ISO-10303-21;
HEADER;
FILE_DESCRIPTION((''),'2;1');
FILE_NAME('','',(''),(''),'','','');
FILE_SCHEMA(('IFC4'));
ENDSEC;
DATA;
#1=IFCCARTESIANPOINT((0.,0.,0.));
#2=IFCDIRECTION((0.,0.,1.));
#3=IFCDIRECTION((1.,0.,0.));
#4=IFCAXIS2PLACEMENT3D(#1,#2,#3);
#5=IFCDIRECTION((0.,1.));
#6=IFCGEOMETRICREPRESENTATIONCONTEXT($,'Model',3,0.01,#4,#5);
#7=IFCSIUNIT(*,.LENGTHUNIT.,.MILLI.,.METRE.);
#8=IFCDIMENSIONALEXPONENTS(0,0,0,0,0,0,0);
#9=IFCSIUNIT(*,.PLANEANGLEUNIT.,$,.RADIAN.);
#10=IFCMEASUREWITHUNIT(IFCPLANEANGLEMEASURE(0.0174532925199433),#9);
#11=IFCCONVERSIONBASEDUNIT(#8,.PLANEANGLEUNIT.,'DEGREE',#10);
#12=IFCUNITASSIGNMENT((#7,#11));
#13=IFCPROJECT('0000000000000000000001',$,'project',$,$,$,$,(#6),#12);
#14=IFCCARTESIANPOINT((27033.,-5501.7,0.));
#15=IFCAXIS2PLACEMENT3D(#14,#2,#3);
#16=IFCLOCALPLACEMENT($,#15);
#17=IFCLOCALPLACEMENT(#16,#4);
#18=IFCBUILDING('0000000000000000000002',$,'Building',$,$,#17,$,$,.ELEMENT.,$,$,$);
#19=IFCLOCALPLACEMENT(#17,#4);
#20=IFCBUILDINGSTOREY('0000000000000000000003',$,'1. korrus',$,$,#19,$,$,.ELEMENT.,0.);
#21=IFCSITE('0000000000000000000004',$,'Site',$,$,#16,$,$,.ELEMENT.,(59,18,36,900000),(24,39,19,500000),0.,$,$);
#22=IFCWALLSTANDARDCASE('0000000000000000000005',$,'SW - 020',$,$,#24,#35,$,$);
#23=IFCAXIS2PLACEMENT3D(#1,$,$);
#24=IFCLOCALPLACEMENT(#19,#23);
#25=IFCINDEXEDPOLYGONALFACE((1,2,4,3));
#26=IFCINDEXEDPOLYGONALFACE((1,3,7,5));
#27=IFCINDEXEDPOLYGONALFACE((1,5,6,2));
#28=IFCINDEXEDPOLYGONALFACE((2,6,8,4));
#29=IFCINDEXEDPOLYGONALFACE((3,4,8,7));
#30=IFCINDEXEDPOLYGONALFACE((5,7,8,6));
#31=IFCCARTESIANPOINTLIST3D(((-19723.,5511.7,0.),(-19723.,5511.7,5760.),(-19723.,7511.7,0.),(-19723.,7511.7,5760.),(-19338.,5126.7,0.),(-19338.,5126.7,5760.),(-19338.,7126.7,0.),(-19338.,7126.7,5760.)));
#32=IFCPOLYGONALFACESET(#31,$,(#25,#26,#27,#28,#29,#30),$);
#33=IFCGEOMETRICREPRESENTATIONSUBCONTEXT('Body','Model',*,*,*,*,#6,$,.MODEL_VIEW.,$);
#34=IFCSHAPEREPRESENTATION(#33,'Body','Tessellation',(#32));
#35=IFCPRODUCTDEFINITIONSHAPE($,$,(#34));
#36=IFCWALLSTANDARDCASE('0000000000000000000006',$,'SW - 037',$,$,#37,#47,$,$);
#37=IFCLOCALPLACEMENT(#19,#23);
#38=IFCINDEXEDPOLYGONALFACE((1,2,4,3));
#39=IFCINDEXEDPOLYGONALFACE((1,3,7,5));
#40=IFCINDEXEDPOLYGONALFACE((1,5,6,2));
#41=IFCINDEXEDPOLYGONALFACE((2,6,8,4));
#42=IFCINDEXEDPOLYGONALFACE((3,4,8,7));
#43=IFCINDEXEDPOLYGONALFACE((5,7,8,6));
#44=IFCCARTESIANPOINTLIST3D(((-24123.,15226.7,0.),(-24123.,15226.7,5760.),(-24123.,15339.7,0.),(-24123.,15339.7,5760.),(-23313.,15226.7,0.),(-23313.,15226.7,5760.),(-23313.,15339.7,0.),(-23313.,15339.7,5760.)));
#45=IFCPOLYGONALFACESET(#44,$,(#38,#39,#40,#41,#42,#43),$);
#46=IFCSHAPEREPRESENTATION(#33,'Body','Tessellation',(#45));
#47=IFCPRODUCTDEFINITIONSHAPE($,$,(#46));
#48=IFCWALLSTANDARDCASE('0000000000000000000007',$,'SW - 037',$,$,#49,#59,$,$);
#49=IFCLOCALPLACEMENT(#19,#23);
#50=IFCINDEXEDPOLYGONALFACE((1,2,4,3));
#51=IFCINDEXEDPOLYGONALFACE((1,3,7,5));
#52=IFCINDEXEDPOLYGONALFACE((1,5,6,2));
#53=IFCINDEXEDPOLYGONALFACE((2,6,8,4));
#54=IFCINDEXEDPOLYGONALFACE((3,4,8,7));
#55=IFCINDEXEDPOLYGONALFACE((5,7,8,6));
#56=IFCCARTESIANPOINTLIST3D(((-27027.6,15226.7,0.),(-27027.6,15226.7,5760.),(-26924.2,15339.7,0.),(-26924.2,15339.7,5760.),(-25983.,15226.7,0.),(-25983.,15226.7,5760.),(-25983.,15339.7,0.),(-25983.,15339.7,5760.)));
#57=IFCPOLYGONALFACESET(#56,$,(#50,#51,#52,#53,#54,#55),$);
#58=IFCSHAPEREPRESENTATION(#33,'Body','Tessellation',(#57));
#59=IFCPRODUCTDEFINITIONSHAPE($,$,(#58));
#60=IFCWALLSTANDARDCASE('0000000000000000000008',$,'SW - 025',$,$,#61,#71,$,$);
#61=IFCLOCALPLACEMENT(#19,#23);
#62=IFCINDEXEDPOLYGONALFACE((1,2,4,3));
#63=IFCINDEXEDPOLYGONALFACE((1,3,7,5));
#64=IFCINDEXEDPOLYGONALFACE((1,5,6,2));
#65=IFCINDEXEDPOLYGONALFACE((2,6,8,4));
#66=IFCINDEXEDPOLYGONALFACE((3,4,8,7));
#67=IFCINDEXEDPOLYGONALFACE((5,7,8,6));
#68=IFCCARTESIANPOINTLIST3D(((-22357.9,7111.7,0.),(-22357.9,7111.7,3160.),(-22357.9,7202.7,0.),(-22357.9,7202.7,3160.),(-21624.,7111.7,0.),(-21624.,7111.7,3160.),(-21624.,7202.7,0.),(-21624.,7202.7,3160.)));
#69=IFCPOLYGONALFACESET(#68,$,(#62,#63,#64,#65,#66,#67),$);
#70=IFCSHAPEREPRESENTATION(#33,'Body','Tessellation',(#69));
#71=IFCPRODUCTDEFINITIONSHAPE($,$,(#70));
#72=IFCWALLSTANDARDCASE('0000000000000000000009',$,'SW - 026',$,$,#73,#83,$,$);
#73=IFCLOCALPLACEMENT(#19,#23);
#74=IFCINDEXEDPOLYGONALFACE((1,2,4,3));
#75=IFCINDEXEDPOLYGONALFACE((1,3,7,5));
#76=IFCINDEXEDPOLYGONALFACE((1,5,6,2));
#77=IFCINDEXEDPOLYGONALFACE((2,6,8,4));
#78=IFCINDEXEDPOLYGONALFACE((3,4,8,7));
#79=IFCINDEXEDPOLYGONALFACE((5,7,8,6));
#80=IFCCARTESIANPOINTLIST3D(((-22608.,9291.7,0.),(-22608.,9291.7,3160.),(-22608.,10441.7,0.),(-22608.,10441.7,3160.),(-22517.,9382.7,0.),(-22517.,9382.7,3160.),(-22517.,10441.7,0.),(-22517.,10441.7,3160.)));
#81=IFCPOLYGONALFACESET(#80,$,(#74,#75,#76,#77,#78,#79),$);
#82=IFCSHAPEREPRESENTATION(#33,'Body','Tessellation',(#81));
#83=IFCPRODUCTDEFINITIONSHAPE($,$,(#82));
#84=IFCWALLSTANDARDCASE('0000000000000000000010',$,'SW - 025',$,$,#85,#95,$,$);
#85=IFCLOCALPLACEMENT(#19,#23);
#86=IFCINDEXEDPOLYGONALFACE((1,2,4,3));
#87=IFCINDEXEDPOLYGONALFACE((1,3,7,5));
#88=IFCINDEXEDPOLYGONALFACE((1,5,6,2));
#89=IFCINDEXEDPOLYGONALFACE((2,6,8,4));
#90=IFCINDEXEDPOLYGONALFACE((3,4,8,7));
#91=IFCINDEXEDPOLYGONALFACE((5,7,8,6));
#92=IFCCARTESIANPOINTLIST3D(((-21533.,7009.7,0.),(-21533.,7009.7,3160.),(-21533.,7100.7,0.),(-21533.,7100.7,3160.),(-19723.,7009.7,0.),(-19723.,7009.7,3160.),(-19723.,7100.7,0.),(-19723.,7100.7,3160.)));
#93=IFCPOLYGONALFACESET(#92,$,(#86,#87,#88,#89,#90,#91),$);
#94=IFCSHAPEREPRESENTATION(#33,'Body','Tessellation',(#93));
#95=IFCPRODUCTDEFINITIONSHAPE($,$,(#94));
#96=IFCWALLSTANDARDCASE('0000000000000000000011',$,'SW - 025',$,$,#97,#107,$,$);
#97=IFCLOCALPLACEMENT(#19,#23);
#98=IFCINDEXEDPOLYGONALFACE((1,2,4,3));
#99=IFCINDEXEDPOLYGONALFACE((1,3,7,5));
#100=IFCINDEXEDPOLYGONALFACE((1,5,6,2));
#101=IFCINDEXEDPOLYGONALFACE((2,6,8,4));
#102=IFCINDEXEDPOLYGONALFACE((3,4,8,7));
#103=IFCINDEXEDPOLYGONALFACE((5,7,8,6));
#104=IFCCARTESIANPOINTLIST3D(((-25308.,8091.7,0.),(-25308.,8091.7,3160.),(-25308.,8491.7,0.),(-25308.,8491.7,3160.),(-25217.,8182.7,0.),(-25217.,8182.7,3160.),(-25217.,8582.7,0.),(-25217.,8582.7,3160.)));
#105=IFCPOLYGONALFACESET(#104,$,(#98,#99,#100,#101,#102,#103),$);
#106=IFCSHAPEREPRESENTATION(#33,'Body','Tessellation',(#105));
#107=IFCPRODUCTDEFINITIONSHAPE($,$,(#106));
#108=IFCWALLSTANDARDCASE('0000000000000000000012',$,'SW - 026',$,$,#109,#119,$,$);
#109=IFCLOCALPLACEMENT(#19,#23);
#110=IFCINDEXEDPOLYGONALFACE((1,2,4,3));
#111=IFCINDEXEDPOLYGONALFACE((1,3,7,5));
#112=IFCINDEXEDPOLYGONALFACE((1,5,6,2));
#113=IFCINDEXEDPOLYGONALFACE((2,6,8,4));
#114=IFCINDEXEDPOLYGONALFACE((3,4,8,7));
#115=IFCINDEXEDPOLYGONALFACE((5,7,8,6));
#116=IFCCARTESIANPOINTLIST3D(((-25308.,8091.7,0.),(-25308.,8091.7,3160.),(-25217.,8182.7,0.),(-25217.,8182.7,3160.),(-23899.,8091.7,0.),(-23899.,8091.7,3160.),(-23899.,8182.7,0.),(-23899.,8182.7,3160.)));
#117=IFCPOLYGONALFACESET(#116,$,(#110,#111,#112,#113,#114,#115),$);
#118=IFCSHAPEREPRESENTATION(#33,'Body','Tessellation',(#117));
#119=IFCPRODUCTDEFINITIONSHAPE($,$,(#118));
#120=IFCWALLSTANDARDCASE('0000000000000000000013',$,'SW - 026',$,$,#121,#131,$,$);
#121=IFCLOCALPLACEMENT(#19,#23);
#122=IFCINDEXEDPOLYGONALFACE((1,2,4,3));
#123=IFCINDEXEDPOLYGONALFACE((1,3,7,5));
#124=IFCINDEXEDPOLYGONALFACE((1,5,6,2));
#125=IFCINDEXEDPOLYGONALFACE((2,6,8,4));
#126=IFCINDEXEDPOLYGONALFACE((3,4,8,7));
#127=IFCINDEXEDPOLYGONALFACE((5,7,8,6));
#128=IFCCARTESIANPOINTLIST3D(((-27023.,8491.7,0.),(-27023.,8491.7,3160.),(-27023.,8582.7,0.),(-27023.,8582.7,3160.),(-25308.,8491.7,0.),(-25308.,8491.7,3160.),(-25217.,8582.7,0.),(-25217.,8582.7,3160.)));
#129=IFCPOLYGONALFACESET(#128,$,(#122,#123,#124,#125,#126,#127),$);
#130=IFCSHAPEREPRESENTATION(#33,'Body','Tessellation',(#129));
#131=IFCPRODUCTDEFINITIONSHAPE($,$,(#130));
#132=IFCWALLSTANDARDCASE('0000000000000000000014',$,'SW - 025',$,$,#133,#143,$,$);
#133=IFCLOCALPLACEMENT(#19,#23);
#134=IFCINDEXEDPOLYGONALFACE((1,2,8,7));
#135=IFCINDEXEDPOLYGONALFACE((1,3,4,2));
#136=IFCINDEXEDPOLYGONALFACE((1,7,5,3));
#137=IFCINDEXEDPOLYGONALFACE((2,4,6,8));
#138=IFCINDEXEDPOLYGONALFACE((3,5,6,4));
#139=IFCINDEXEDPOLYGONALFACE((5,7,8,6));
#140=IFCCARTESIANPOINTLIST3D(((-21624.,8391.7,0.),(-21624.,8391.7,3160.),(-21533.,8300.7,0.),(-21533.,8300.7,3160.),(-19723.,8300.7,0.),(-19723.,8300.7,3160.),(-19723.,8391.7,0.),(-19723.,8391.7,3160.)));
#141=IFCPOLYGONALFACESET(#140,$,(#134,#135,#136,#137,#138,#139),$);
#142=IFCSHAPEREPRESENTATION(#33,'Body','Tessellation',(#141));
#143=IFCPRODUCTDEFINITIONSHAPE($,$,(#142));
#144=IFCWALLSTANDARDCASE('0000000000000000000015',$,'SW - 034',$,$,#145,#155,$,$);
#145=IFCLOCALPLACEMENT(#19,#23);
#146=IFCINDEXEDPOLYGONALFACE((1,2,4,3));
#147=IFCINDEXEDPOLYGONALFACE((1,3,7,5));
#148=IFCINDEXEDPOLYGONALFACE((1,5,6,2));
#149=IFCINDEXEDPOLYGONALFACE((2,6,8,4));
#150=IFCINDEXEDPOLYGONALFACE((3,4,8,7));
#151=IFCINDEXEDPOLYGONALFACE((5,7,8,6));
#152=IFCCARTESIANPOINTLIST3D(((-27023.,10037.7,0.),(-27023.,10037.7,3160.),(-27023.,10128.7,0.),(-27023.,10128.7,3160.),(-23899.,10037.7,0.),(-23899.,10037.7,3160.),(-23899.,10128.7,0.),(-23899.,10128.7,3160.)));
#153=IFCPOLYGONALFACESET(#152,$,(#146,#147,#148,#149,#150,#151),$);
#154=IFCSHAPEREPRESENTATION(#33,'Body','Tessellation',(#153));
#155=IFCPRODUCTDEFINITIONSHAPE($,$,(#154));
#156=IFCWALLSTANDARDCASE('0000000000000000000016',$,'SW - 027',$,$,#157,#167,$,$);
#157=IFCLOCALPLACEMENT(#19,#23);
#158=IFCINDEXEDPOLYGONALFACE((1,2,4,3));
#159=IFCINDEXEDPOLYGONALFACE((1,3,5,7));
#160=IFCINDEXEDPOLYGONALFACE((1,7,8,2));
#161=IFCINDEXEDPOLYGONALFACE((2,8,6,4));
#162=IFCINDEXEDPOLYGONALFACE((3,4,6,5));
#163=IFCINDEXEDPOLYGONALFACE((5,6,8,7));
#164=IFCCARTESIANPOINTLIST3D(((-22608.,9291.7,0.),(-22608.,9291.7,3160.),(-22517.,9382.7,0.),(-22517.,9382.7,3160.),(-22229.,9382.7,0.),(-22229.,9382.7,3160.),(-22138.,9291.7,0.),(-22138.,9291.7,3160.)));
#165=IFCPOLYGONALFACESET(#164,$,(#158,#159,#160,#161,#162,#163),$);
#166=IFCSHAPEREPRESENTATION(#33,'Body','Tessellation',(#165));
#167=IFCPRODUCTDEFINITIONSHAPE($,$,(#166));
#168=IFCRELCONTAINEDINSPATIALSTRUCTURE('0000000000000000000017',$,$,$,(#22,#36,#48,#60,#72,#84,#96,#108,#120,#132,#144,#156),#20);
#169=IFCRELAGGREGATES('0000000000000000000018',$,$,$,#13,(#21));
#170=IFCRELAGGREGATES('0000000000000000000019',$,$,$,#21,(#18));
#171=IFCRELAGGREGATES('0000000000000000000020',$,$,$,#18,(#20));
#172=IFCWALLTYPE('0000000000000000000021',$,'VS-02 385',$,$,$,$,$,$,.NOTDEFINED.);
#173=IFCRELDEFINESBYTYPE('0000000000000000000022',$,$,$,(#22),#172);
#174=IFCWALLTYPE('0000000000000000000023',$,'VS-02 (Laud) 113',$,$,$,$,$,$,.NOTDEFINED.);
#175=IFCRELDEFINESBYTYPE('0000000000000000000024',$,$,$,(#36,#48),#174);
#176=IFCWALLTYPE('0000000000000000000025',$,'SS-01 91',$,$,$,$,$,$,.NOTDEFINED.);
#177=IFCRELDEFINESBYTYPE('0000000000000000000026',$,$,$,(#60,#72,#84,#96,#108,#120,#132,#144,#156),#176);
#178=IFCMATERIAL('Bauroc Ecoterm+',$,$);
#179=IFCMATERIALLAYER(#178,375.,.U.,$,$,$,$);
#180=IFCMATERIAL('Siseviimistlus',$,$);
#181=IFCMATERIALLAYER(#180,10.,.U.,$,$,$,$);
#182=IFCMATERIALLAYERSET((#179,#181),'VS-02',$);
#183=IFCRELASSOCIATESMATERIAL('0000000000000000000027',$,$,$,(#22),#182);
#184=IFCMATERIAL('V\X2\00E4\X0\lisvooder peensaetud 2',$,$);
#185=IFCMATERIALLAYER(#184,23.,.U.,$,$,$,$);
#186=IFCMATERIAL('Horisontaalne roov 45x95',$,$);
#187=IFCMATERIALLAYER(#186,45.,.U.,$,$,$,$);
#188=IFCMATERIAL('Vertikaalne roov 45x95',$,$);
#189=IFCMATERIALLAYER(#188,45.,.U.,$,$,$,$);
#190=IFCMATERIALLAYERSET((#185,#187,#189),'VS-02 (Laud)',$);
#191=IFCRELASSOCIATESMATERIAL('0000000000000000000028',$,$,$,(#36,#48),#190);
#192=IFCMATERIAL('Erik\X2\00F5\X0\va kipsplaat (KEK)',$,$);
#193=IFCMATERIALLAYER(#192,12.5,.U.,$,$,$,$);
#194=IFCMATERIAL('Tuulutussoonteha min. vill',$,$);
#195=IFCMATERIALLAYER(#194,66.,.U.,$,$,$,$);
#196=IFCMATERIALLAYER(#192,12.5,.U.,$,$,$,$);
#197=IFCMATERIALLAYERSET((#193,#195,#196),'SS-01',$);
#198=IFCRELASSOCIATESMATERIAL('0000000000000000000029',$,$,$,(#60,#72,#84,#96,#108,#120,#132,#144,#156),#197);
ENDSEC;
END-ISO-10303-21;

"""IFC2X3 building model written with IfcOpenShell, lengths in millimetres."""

from ifc_helpers import new_model, entity, si_unit, converted_unit, direction, frame, origin_with_axes, place, context, subcontext, project, spatial, polyline, outline, extrude, material, layer, layer_set, layer_usage, type_object, element, save


model = new_model("IFC2X3")

# Units and contexts
model_context = context("Model", 3, precision=0.01, world=origin_with_axes(), true_north=direction((0.0, 1.0)))
body_context = subcontext(model_context, "Body", "Model", "MODEL_VIEW")
ifc_project = project(units=[si_unit("LENGTHUNIT", "METRE", prefix="MILLI"), converted_unit("PLANEANGLEUNIT", "DEGREE", entity("IfcPlaneAngleMeasure", 0.0174532925199433), si_unit("PLANEANGLEUNIT", "RADIAN"), dimensions=[0, 0, 0, 0, 0, 0, 0])], contexts=[model_context])

# Site, building, storey
site_placement = place(None, frame((27033.0, -5501.7, 0.0), z_axis=(0.0, 0.0, 1.0), x_axis=(1.0, 0.0, 0.0)))
site = spatial("IfcSite", under=ifc_project, at=site_placement, Name="Site", CompositionType="ELEMENT", RefLatitude=(59, 18, 36, 900000), RefLongitude=(24, 39, 19, 500000), RefElevation=0.0)
building_placement = place(site_placement, origin_with_axes())
building = spatial("IfcBuilding", under=site, at=building_placement, Name="Building", CompositionType="ELEMENT")
storey_placement = place(building_placement, origin_with_axes())
storey = spatial("IfcBuildingStorey", under=building, at=storey_placement, Name="1. korrus", CompositionType="ELEMENT", Elevation=0.0)

# Wall
ifc_material_1 = material(Name="Bauroc Ecoterm+")
ifc_layer_1 = layer(ifc_material_1, 375.0, ventilated="UNKNOWN")
ifc_material_2 = material(Name="Siseviimistlus")
ifc_layer_2 = layer(ifc_material_2, 10.0, ventilated="UNKNOWN")
ifc_layer_set_1 = layer_set([ifc_layer_1, ifc_layer_2], Name="VS-02")
ifc_layer_usage_1 = layer_usage(ifc_layer_set_1, "AXIS2", "NEGATIVE", 385.0)
wall_type_1 = type_object("IfcWallType", Name="VS-02 385", PredefinedType="NOTDEFINED")
wall_1_placement = place(storey_placement, frame((-19723.0, 7511.7, 0.0), z_axis=(0.0, 0.0, 1.0), x_axis=(0.0, -1.0, 0.0)))
element("IfcWallStandardCase", 1, at=wall_1_placement, inside=storey, type_object=wall_type_1, material=ifc_layer_usage_1, Name="SW - 020", context=body_context, shape_type="SweptSolid", body=[
    extrude(outline(polyline([(0.0, 0.0), (2000.0, 0.0), (2385.0, 385.0), (385.0, 385.0), (0.0, 0.0)])), origin_with_axes(), (0.0, 0.0, 1.0), 5760.0),
])

# Walls
ifc_material_3 = material(Name="Välisvooder peensaetud 2")
ifc_layer_3 = layer(ifc_material_3, 23.0, ventilated="UNKNOWN")
ifc_material_4 = material(Name="Horisontaalne roov 45x95")
ifc_layer_4 = layer(ifc_material_4, 45.0, ventilated="UNKNOWN")
ifc_material_5 = material(Name="Vertikaalne roov 45x95")
ifc_layer_5 = layer(ifc_material_5, 45.0, ventilated="UNKNOWN")
ifc_layer_set_2 = layer_set([ifc_layer_3, ifc_layer_4, ifc_layer_5], Name="VS-02 (Laud)")
ifc_layer_usage_2 = layer_usage(ifc_layer_set_2, "AXIS2", "POSITIVE", -113.0)
wall_type_2 = type_object("IfcWallType", Name="VS-02 (Laud) 113", PredefinedType="NOTDEFINED")
wall_2_placement = place(storey_placement, frame((-23313.0, 15226.7, 0.0), z_axis=(0.0, 0.0, 1.0), x_axis=(-1.0, 0.0, 0.0)))
element("IfcWallStandardCase", 2, at=wall_2_placement, inside=storey, type_object=wall_type_2, material=ifc_layer_usage_2, Name="SW - 037", context=body_context, shape_type="SweptSolid", body=[
    extrude(outline(polyline([(0.0, -113.0), (810.0, -113.0), (810.0, 0.0), (0.0, 0.0), (0.0, -113.0)])), origin_with_axes(), (0.0, 0.0, 1.0), 5760.0),
])
ifc_layer_usage_3 = layer_usage(ifc_layer_set_2, "AXIS2", "POSITIVE", -113.0)
wall_3_placement = place(storey_placement, frame((-25983.0, 15226.7, 0.0), z_axis=(0.0, 0.0, 1.0), x_axis=(-1.0, 0.0, 0.0)))
element("IfcWallStandardCase", 3, at=wall_3_placement, inside=storey, type_object=wall_type_2, material=ifc_layer_usage_3, Name="SW - 037", context=body_context, shape_type="SweptSolid", body=[
    extrude(outline(polyline([(0.0, -113.0), (941.2, -113.0), (1044.7, 0.0), (0.0, 0.0), (0.0, -113.0)])), origin_with_axes(), (0.0, 0.0, 1.0), 5760.0),
])
ifc_material_6 = material(Name="Erikõva kipsplaat (KEK)")
ifc_layer_6 = layer(ifc_material_6, 12.5, ventilated="UNKNOWN")
ifc_material_7 = material(Name="Tuulutussoonteha min. vill")
ifc_layer_7 = layer(ifc_material_7, 66.0, ventilated="UNKNOWN")
ifc_layer_8 = layer(ifc_material_6, 12.5, ventilated="UNKNOWN")
ifc_layer_set_3 = layer_set([ifc_layer_6, ifc_layer_7, ifc_layer_8], Name="SS-01")
ifc_layer_usage_4 = layer_usage(ifc_layer_set_3, "AXIS2", "POSITIVE", -91.0)
wall_type_3 = type_object("IfcWallType", Name="SS-01 91", PredefinedType="NOTDEFINED")
wall_4_placement = place(storey_placement, frame((-22357.9, 7202.7, 0.0), z_axis=(0.0, 0.0, 1.0), x_axis=(1.0, 0.0, 0.0)))
element("IfcWallStandardCase", 4, at=wall_4_placement, inside=storey, type_object=wall_type_3, material=ifc_layer_usage_4, Name="SW - 025", context=body_context, shape_type="SweptSolid", body=[
    extrude(outline(polyline([(0.0, -91.0), (733.9, -91.0), (733.9, 0.0), (0.0, 0.0), (0.0, -91.0)])), origin_with_axes(), (0.0, 0.0, 1.0), 3160.0),
])
ifc_layer_usage_5 = layer_usage(ifc_layer_set_3, "AXIS2", "NEGATIVE", 91.0)
wall_5_placement = place(storey_placement, frame((-22608.0, 10441.7, 0.0), z_axis=(0.0, 0.0, 1.0), x_axis=(0.0, -1.0, 0.0)))
element("IfcWallStandardCase", 5, at=wall_5_placement, inside=storey, type_object=wall_type_3, material=ifc_layer_usage_5, Name="SW - 026", context=body_context, shape_type="SweptSolid", body=[
    extrude(outline(polyline([(0.0, 0.0), (1150.0, 0.0), (1059.0, 91.0), (0.0, 91.0), (0.0, 0.0)])), origin_with_axes(), (0.0, 0.0, 1.0), 3160.0),
])
ifc_layer_usage_6 = layer_usage(ifc_layer_set_3, "AXIS2", "POSITIVE", -91.0)
wall_6_placement = place(storey_placement, frame((-19723.0, 7009.7, 0.0), z_axis=(0.0, 0.0, 1.0), x_axis=(-1.0, 0.0, 0.0)))
element("IfcWallStandardCase", 6, at=wall_6_placement, inside=storey, type_object=wall_type_3, material=ifc_layer_usage_6, Name="SW - 025", context=body_context, shape_type="SweptSolid", body=[
    extrude(outline(polyline([(0.0, -91.0), (1810.0, -91.0), (1810.0, 0.0), (0.0, 0.0), (0.0, -91.0)])), origin_with_axes(), (0.0, 0.0, 1.0), 3160.0),
])
ifc_layer_usage_7 = layer_usage(ifc_layer_set_3, "AXIS2", "POSITIVE", -91.0)
wall_7_placement = place(storey_placement, frame((-25308.0, 8091.7, 0.0), z_axis=(0.0, 0.0, 1.0), x_axis=(0.0, 1.0, 0.0)))
element("IfcWallStandardCase", 7, at=wall_7_placement, inside=storey, type_object=wall_type_3, material=ifc_layer_usage_7, Name="SW - 025", context=body_context, shape_type="SweptSolid", body=[
    extrude(outline(polyline([(91.0, -91.0), (491.0, -91.0), (400.0, 0.0), (0.0, 0.0), (91.0, -91.0)])), origin_with_axes(), (0.0, 0.0, 1.0), 3160.0),
])
ifc_layer_usage_8 = layer_usage(ifc_layer_set_3, "AXIS2", "NEGATIVE", 91.0)
wall_8_placement = place(storey_placement, frame((-25308.0, 8091.7, 0.0), z_axis=(0.0, 0.0, 1.0), x_axis=(1.0, 0.0, 0.0)))
element("IfcWallStandardCase", 8, at=wall_8_placement, inside=storey, type_object=wall_type_3, material=ifc_layer_usage_8, Name="SW - 026", context=body_context, shape_type="SweptSolid", body=[
    extrude(outline(polyline([(0.0, 0.0), (1409.0, 0.0), (1409.0, 91.0), (91.0, 91.0), (0.0, 0.0)])), origin_with_axes(), (0.0, 0.0, 1.0), 3160.0),
])
ifc_layer_usage_9 = layer_usage(ifc_layer_set_3, "AXIS2", "POSITIVE", -91.0)
wall_9_placement = place(storey_placement, frame((-25308.0, 8491.7, 0.0), z_axis=(0.0, 0.0, 1.0), x_axis=(-1.0, 0.0, 0.0)))
element("IfcWallStandardCase", 9, at=wall_9_placement, inside=storey, type_object=wall_type_3, material=ifc_layer_usage_9, Name="SW - 026", context=body_context, shape_type="SweptSolid", body=[
    extrude(outline(polyline([(-91.0, -91.0), (1715.0, -91.0), (1715.0, 0.0), (0.0, 0.0), (-91.0, -91.0)])), origin_with_axes(), (0.0, 0.0, 1.0), 3160.0),
])
ifc_layer_usage_10 = layer_usage(ifc_layer_set_3, "AXIS2", "NEGATIVE", 91.0)
wall_10_placement = place(storey_placement, frame((-19723.0, 8391.7, 0.0), z_axis=(0.0, 0.0, 1.0), x_axis=(-1.0, 0.000001, 0.0)))
element("IfcWallStandardCase", 10, at=wall_10_placement, inside=storey, type_object=wall_type_3, material=ifc_layer_usage_10, Name="SW - 025", context=body_context, shape_type="SweptSolid", body=[
    extrude(outline(polyline([(0.0, 0.0), (1901.0, 0.0), (1810.0, 91.0), (0.0, 91.0), (0.0, 0.0)])), origin_with_axes(), (0.0, 0.0, 1.0), 3160.0),
])
ifc_layer_usage_11 = layer_usage(ifc_layer_set_3, "AXIS2", "NEGATIVE", 91.0)
wall_11_placement = place(storey_placement, frame((-27023.0, 10037.7, 0.0), z_axis=(0.0, 0.0, 1.0), x_axis=(1.0, 0.0, 0.0)))
element("IfcWallStandardCase", 11, at=wall_11_placement, inside=storey, type_object=wall_type_3, material=ifc_layer_usage_11, Name="SW - 034", context=body_context, shape_type="SweptSolid", body=[
    extrude(outline(polyline([(0.0, 0.0), (3124.0, 0.0), (3124.0, 91.0), (0.0, 91.0), (0.0, 0.0)])), origin_with_axes(), (0.0, 0.0, 1.0), 3160.0),
])
ifc_layer_usage_12 = layer_usage(ifc_layer_set_3, "AXIS2", "NEGATIVE", 91.0)
wall_12_placement = place(storey_placement, frame((-22608.0, 9291.7, 0.0), z_axis=(0.0, 0.0, 1.0), x_axis=(1.0, 0.0, 0.0)))
element("IfcWallStandardCase", 12, at=wall_12_placement, inside=storey, type_object=wall_type_3, material=ifc_layer_usage_12, Name="SW - 027", context=body_context, shape_type="SweptSolid", body=[
    extrude(outline(polyline([(0.0, 0.0), (470.0, 0.0), (379.0, 91.0), (91.0, 91.0), (0.0, 0.0)])), origin_with_axes(), (0.0, 0.0, 1.0), 3160.0),
])

save(model, "model.ifc")
